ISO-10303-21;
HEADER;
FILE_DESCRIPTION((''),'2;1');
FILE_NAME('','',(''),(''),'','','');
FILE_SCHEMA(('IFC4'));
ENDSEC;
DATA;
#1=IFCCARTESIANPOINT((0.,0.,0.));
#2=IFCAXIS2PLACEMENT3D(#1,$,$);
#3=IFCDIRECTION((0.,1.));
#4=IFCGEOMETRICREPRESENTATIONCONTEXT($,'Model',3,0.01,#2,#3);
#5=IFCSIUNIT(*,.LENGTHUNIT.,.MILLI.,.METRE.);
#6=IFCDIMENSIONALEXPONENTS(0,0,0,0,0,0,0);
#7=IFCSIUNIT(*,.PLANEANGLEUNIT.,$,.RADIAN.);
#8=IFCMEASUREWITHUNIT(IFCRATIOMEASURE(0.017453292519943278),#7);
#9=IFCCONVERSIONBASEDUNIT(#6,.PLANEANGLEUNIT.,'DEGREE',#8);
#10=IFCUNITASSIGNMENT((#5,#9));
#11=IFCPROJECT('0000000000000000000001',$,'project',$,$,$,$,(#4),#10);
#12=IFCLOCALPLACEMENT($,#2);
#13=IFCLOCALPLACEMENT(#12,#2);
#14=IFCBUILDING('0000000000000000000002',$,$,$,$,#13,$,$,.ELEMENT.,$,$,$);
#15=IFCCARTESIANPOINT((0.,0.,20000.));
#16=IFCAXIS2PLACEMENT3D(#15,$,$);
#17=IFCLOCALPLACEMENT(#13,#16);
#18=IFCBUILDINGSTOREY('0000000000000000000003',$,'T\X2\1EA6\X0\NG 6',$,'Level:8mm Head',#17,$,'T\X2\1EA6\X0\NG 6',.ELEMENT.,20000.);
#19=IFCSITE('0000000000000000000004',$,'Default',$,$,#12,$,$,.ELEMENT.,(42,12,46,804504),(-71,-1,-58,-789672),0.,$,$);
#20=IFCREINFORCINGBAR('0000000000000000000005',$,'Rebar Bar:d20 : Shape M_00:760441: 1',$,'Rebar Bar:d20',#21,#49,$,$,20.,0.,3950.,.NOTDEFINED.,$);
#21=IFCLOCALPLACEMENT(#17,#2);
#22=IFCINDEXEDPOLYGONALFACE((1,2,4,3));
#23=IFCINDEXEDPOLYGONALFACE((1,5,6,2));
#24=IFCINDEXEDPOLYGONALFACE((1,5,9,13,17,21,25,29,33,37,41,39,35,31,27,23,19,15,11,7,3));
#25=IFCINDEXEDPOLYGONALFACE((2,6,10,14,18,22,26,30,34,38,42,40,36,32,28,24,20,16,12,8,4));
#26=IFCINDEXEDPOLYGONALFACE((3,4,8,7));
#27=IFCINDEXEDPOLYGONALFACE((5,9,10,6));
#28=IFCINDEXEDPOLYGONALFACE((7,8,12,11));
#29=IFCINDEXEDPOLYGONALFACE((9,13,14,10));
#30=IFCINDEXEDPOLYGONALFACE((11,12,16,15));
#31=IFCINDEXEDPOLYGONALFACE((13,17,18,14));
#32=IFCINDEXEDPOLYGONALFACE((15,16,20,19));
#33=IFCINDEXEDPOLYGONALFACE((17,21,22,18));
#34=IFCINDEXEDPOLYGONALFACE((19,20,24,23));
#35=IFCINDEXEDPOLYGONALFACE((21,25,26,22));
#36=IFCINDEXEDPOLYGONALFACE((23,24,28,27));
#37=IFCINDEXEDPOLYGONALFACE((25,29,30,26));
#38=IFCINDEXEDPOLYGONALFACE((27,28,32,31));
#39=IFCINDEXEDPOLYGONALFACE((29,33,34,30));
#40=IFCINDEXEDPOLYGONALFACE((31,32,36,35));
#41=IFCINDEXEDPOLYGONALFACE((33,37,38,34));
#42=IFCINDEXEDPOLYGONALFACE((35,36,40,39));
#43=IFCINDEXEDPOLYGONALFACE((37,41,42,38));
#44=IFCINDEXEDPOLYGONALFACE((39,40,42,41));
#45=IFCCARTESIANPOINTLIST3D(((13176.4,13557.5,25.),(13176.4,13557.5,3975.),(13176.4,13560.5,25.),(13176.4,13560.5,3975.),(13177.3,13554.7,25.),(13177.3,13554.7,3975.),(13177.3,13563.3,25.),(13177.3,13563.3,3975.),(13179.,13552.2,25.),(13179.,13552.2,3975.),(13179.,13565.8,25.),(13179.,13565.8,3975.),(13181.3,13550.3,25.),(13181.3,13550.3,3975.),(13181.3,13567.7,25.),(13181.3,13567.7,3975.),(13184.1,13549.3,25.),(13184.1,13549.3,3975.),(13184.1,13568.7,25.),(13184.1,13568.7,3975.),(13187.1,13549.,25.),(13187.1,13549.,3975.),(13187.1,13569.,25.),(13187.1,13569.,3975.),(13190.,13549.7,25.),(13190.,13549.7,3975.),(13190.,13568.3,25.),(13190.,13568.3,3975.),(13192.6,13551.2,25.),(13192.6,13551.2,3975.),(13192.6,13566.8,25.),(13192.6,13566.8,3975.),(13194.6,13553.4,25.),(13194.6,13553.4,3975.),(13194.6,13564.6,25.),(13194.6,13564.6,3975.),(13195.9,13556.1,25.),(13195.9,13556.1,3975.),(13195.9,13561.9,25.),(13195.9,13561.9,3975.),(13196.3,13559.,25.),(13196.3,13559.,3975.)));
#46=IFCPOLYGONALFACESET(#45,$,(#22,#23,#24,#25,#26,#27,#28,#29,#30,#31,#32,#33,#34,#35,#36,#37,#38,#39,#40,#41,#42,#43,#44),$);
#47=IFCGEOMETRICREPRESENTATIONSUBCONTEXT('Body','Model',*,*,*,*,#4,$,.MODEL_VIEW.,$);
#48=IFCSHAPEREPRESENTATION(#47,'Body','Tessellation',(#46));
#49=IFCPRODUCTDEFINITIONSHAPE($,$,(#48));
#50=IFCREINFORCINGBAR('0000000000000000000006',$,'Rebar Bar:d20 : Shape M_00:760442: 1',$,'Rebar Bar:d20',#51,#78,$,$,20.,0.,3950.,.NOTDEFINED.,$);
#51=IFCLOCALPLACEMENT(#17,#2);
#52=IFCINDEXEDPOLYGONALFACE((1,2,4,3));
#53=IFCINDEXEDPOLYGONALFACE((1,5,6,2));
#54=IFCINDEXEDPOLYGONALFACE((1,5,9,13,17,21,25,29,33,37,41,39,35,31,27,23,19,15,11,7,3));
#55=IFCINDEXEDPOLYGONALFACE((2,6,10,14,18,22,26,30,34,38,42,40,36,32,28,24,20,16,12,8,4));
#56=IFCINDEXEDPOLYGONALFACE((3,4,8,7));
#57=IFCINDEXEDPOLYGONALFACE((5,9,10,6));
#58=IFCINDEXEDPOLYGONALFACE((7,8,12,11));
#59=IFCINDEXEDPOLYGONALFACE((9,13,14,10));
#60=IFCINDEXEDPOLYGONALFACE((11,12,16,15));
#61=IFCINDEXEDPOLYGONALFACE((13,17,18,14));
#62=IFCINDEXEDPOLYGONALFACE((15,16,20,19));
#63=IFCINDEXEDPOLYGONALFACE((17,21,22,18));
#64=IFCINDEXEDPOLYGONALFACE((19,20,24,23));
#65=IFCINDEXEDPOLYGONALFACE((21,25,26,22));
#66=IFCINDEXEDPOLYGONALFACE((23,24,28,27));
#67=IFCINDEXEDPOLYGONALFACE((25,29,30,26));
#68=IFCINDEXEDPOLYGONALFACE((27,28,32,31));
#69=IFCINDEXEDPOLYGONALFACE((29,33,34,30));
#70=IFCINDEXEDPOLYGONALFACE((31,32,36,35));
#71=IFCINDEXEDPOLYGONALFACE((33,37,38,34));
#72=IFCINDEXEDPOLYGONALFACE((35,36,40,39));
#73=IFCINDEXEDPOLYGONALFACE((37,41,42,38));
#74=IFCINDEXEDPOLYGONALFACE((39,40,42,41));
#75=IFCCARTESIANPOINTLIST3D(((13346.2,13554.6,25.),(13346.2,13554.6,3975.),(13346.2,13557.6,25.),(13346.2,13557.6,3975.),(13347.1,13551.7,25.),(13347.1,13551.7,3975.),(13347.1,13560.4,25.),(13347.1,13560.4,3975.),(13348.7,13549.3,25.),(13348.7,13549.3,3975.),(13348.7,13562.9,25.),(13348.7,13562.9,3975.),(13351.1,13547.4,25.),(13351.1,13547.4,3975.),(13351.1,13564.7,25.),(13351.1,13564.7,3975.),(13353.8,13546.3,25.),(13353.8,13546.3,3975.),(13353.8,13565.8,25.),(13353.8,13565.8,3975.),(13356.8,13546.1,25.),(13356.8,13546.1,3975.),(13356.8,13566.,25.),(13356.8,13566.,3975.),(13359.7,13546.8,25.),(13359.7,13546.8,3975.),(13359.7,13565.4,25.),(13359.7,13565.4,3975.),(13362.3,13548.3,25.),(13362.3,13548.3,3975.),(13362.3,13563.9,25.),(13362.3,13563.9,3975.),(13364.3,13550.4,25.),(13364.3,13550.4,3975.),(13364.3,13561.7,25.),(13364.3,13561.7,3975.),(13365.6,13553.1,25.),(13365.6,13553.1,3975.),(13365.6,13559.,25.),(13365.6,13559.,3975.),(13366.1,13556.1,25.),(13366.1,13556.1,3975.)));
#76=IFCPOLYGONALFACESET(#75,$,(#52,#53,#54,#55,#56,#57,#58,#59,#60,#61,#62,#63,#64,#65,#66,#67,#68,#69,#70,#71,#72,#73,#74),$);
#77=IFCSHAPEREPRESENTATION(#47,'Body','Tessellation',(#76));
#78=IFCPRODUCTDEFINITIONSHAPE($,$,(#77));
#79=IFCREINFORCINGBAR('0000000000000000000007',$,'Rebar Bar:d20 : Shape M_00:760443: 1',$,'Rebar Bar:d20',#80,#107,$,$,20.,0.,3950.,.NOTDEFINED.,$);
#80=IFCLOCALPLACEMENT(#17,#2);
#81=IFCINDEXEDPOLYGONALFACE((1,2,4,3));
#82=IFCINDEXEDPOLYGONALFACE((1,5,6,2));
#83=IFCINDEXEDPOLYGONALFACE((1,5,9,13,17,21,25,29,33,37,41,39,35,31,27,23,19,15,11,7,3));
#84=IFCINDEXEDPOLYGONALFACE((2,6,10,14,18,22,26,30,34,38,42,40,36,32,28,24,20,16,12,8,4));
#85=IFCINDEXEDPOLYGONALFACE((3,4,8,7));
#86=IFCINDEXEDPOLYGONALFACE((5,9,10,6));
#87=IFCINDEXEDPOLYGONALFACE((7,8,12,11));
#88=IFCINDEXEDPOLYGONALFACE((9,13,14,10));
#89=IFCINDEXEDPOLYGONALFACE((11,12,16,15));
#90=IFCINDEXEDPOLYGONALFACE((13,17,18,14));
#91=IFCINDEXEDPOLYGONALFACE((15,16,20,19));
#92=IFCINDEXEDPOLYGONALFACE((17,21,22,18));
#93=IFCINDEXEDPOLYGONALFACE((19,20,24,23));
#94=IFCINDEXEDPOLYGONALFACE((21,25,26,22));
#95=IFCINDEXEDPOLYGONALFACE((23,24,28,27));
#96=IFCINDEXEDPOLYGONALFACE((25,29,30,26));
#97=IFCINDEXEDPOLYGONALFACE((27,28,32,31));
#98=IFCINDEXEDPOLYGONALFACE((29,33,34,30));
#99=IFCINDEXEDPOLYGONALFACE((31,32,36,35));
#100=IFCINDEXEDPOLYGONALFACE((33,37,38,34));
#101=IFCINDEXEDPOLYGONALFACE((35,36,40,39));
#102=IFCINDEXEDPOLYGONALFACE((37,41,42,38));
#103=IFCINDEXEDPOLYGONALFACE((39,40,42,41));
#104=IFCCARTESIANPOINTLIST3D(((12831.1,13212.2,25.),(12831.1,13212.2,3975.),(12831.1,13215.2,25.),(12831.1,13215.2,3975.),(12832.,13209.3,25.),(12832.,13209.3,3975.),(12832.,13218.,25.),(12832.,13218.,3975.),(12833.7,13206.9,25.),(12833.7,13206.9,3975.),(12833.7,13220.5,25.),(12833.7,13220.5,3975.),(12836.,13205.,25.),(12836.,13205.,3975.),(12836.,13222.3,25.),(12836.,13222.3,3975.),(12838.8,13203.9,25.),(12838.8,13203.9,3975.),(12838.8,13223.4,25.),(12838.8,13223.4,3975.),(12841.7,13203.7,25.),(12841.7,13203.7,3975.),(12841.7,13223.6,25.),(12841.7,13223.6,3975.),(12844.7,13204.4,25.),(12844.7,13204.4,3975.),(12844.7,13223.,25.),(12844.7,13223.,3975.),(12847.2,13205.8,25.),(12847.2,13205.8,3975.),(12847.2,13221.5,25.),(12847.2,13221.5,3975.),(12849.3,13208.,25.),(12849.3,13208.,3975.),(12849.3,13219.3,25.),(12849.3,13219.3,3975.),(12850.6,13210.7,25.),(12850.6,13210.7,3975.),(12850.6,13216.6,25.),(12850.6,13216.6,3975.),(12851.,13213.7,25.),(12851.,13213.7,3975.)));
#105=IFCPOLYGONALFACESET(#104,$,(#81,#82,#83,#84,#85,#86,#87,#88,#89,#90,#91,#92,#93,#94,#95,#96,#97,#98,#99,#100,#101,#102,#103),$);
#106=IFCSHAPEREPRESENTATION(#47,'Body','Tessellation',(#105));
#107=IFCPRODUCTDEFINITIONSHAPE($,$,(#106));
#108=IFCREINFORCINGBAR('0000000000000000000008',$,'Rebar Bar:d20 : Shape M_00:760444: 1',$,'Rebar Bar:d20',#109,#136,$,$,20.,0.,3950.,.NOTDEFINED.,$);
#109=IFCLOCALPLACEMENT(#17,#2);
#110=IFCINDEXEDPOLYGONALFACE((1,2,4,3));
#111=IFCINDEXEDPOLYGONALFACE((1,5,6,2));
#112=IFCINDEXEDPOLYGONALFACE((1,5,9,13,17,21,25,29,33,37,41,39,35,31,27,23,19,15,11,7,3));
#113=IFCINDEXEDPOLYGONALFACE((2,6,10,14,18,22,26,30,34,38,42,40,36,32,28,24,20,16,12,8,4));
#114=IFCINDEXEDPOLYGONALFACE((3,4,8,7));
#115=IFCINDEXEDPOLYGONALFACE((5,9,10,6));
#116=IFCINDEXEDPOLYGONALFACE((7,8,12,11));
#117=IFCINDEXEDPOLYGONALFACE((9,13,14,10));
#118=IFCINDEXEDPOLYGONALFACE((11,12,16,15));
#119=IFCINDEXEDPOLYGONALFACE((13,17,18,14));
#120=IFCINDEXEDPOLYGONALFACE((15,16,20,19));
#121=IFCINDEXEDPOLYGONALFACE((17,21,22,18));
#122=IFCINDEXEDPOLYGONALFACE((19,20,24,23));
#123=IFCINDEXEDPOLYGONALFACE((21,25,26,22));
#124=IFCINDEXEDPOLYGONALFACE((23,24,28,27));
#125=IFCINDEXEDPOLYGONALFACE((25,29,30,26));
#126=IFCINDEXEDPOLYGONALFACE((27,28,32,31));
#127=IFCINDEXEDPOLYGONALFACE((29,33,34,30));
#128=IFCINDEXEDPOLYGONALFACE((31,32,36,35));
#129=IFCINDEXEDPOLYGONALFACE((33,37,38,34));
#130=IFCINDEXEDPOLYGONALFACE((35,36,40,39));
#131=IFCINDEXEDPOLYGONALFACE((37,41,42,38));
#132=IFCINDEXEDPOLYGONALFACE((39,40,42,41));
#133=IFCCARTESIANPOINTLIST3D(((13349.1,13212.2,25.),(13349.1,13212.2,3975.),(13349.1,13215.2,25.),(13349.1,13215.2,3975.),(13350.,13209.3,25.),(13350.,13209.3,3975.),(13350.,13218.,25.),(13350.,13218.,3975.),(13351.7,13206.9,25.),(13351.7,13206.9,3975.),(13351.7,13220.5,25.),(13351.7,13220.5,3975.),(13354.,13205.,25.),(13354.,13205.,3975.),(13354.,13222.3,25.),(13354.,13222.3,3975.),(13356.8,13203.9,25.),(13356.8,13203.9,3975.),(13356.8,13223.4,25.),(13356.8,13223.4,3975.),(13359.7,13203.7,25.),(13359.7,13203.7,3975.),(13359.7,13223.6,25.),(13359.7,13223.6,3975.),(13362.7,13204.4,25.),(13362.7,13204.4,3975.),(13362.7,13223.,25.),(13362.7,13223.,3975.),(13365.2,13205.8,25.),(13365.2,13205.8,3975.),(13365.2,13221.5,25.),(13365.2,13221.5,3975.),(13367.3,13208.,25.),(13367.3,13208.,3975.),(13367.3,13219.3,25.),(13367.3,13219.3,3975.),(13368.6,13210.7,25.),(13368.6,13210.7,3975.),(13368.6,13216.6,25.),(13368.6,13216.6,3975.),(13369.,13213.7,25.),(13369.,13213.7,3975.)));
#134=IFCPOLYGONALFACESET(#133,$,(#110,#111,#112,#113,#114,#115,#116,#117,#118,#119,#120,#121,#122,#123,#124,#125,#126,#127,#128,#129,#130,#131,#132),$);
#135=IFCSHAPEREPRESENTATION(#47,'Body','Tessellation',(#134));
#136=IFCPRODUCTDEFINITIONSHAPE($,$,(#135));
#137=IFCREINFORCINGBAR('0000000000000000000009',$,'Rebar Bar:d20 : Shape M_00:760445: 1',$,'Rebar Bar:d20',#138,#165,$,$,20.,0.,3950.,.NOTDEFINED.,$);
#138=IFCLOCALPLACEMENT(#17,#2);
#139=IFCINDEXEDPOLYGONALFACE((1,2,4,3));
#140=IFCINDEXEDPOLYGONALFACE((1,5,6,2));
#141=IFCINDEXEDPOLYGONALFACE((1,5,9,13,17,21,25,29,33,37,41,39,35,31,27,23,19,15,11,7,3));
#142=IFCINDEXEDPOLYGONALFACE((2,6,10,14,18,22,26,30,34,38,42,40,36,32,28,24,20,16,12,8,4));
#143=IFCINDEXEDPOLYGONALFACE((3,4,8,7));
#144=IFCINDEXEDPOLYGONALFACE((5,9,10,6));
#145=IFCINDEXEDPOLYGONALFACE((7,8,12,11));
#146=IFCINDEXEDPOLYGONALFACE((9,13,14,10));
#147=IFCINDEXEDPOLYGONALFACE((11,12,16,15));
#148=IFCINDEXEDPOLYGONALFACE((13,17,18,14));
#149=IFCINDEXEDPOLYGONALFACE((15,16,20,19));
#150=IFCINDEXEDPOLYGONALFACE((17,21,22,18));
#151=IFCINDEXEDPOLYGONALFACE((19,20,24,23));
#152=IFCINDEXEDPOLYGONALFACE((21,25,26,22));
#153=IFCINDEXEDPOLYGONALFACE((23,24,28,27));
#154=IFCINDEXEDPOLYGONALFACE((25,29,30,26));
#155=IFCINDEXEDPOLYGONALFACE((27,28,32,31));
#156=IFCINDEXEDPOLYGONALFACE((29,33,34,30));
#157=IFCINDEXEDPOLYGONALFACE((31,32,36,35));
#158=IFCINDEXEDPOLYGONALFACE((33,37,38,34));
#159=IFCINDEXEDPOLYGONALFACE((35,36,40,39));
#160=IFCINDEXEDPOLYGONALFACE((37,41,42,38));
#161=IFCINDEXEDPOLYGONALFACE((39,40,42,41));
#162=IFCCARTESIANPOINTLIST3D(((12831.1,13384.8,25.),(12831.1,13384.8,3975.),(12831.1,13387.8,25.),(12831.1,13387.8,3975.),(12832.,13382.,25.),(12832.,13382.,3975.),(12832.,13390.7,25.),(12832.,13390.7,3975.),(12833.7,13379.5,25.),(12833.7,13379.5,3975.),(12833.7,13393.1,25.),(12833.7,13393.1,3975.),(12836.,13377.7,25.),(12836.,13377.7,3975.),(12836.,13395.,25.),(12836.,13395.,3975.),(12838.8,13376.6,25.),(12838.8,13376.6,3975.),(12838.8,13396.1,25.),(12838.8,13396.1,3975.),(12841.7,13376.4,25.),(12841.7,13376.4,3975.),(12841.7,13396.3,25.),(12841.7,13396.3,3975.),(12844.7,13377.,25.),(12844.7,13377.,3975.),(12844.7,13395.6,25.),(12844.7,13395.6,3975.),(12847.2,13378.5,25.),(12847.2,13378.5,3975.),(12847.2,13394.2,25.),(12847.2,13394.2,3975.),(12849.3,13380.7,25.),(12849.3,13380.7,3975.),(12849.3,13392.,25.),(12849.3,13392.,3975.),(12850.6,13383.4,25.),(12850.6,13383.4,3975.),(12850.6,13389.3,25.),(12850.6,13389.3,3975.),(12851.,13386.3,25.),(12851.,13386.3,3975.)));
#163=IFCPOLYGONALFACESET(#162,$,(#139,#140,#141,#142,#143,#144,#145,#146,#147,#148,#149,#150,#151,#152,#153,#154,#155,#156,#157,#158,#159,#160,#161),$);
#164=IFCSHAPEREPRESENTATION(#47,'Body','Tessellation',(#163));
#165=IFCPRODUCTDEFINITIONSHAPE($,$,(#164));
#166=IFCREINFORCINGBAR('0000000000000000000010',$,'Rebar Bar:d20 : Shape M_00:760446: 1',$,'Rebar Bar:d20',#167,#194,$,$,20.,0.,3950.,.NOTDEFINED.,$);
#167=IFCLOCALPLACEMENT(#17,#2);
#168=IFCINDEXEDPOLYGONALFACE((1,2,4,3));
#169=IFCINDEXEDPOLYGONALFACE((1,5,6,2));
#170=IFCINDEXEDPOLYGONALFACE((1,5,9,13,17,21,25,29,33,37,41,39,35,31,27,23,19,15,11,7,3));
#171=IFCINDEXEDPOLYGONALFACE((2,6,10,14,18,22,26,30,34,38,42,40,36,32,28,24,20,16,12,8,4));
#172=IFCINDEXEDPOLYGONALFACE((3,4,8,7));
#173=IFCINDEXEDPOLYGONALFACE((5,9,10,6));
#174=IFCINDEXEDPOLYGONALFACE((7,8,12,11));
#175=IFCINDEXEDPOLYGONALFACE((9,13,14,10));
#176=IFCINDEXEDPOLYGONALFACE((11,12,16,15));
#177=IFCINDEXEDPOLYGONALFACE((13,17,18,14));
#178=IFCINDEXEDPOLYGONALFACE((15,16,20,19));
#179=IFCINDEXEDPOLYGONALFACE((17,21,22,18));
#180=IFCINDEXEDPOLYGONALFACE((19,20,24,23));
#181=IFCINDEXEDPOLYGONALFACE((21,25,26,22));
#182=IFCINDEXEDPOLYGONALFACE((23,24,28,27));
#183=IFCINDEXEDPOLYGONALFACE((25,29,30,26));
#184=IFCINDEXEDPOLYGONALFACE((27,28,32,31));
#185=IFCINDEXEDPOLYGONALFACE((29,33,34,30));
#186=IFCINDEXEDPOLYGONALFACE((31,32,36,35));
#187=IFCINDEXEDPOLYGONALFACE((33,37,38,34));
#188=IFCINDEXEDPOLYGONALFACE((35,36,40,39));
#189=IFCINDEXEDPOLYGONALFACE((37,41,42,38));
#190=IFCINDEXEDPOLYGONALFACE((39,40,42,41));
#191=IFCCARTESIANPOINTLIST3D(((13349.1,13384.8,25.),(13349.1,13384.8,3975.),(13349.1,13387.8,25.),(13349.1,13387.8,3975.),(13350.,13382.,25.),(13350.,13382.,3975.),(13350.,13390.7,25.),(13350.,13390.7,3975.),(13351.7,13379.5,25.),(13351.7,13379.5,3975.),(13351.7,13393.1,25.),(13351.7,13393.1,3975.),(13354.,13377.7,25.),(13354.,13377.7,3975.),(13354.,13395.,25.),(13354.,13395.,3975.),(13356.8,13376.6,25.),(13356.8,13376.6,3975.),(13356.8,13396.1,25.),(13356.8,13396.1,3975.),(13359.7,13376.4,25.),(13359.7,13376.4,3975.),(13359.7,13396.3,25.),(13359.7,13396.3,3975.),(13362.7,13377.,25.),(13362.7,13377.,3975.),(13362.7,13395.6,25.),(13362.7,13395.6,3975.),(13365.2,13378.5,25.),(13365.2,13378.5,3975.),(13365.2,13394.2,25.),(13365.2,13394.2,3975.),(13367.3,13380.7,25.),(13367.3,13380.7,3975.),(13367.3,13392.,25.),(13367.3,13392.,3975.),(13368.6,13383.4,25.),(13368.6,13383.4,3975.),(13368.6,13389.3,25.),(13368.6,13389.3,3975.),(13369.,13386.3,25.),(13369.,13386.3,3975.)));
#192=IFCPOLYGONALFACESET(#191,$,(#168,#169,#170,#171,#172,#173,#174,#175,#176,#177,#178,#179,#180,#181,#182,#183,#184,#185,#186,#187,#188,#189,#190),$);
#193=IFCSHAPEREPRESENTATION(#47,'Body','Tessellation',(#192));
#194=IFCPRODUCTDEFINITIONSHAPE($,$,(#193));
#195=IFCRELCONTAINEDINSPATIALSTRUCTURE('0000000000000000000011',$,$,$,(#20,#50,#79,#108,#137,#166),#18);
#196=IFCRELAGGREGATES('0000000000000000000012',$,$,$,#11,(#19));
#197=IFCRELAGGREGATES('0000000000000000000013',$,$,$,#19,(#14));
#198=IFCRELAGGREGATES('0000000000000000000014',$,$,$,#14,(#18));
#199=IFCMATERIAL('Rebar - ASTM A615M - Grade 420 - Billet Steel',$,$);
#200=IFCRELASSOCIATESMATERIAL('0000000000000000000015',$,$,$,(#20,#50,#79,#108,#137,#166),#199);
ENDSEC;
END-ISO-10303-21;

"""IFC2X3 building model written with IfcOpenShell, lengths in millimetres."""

from ifc_helpers import new_model, entity, si_unit, converted_unit, direction, frame, origin, place, context, subcontext, project, spatial, material, element, save


model = new_model("IFC2X3")

# Units and contexts
model_context = context("Model", 3, precision=0.01, world=origin(), true_north=direction((0.0, 1.0)))
body_context = subcontext(model_context, "Body", "Model", "MODEL_VIEW")
ifc_project = project(units=[si_unit("LENGTHUNIT", "METRE", prefix="MILLI"), converted_unit("PLANEANGLEUNIT", "DEGREE", entity("IfcRatioMeasure", 0.017453292519943278), si_unit("PLANEANGLEUNIT", "RADIAN"), dimensions=[0, 0, 0, 0, 0, 0, 0])], contexts=[model_context])

# Site, building, storey
site_placement = place(None, origin())
site = spatial("IfcSite", under=ifc_project, at=site_placement, Name="Default", CompositionType="ELEMENT", RefLatitude=(42, 12, 46, 804504), RefLongitude=(-71, -1, -58, -789672), RefElevation=0.0)
building_placement = place(site_placement, origin())
building = spatial("IfcBuilding", under=site, at=building_placement, CompositionType="ELEMENT")
storey_placement = place(building_placement, frame((0.0, 0.0, 20000.0)))
storey = spatial("IfcBuildingStorey", under=building, at=storey_placement, Name="TẦNG 6", ObjectType="Level:8mm Head", LongName="TẦNG 6", CompositionType="ELEMENT", Elevation=20000.0)

# Reinforcing bars
ifc_material = material(Name="Rebar - ASTM A615M - Grade 420 - Billet Steel")
reinforcing_bar_1_placement = place(storey_placement, origin())
element("IfcReinforcingBar", 1, at=reinforcing_bar_1_placement, inside=storey, material=ifc_material, Name="Rebar Bar:d20 : Shape M_00:760441: 1", ObjectType="Rebar Bar:d20", BarLength=3950.0, BarRole="NOTDEFINED", CrossSectionArea=0.0, NominalDiameter=20.0, context=body_context, shape_type="AdvancedSweptSolid", body=[
    entity("IfcSweptDiskSolid", entity("IfcCompositeCurve", [entity("IfcCompositeCurveSegment", "CONTINUOUS", True, entity("IfcPolyline", [entity("IfcCartesianPoint", [13186.3, 13559.0, 25.0]), entity("IfcCartesianPoint", [13186.3, 13559.0, 3975.0])]))], False), 10.0, None, 0.0, 1.0),
])
reinforcing_bar_2_placement = place(storey_placement, origin())
element("IfcReinforcingBar", 2, at=reinforcing_bar_2_placement, inside=storey, material=ifc_material, Name="Rebar Bar:d20 : Shape M_00:760442: 1", ObjectType="Rebar Bar:d20", BarLength=3950.0, BarRole="NOTDEFINED", CrossSectionArea=0.0, NominalDiameter=20.0, context=body_context, shape_type="AdvancedSweptSolid", body=[
    entity("IfcSweptDiskSolid", entity("IfcCompositeCurve", [entity("IfcCompositeCurveSegment", "CONTINUOUS", True, entity("IfcPolyline", [entity("IfcCartesianPoint", [13356.1, 13556.1, 25.0]), entity("IfcCartesianPoint", [13356.1, 13556.1, 3975.0])]))], False), 10.0, None, 0.0, 1.0),
])
reinforcing_bar_3_placement = place(storey_placement, origin())
element("IfcReinforcingBar", 3, at=reinforcing_bar_3_placement, inside=storey, material=ifc_material, Name="Rebar Bar:d20 : Shape M_00:760443: 1", ObjectType="Rebar Bar:d20", BarLength=3950.0, BarRole="NOTDEFINED", CrossSectionArea=0.0, NominalDiameter=20.0, context=body_context, shape_type="AdvancedSweptSolid", body=[
    entity("IfcSweptDiskSolid", entity("IfcCompositeCurve", [entity("IfcCompositeCurveSegment", "CONTINUOUS", True, entity("IfcPolyline", [entity("IfcCartesianPoint", [12841.0, 13213.7, 25.0]), entity("IfcCartesianPoint", [12841.0, 13213.7, 3975.0])]))], False), 10.0, None, 0.0, 1.0),
])
reinforcing_bar_4_placement = place(storey_placement, origin())
element("IfcReinforcingBar", 4, at=reinforcing_bar_4_placement, inside=storey, material=ifc_material, Name="Rebar Bar:d20 : Shape M_00:760444: 1", ObjectType="Rebar Bar:d20", BarLength=3950.0, BarRole="NOTDEFINED", CrossSectionArea=0.0, NominalDiameter=20.0, context=body_context, shape_type="AdvancedSweptSolid", body=[
    entity("IfcSweptDiskSolid", entity("IfcCompositeCurve", [entity("IfcCompositeCurveSegment", "CONTINUOUS", True, entity("IfcPolyline", [entity("IfcCartesianPoint", [13359.0, 13213.7, 25.0]), entity("IfcCartesianPoint", [13359.0, 13213.7, 3975.0])]))], False), 10.0, None, 0.0, 1.0),
])
reinforcing_bar_5_placement = place(storey_placement, origin())
element("IfcReinforcingBar", 5, at=reinforcing_bar_5_placement, inside=storey, material=ifc_material, Name="Rebar Bar:d20 : Shape M_00:760445: 1", ObjectType="Rebar Bar:d20", BarLength=3950.0, BarRole="NOTDEFINED", CrossSectionArea=0.0, NominalDiameter=20.0, context=body_context, shape_type="AdvancedSweptSolid", body=[
    entity("IfcSweptDiskSolid", entity("IfcCompositeCurve", [entity("IfcCompositeCurveSegment", "CONTINUOUS", True, entity("IfcPolyline", [entity("IfcCartesianPoint", [12841.0, 13386.3, 25.0]), entity("IfcCartesianPoint", [12841.0, 13386.3, 3975.0])]))], False), 10.0, None, 0.0, 1.0),
])
reinforcing_bar_6_placement = place(storey_placement, origin())
element("IfcReinforcingBar", 6, at=reinforcing_bar_6_placement, inside=storey, material=ifc_material, Name="Rebar Bar:d20 : Shape M_00:760446: 1", ObjectType="Rebar Bar:d20", BarLength=3950.0, BarRole="NOTDEFINED", CrossSectionArea=0.0, NominalDiameter=20.0, context=body_context, shape_type="AdvancedSweptSolid", body=[
    entity("IfcSweptDiskSolid", entity("IfcCompositeCurve", [entity("IfcCompositeCurveSegment", "CONTINUOUS", True, entity("IfcPolyline", [entity("IfcCartesianPoint", [13359.0, 13386.3, 25.0]), entity("IfcCartesianPoint", [13359.0, 13386.3, 3975.0])]))], False), 10.0, None, 0.0, 1.0),
])

save(model, "model.ifc")
